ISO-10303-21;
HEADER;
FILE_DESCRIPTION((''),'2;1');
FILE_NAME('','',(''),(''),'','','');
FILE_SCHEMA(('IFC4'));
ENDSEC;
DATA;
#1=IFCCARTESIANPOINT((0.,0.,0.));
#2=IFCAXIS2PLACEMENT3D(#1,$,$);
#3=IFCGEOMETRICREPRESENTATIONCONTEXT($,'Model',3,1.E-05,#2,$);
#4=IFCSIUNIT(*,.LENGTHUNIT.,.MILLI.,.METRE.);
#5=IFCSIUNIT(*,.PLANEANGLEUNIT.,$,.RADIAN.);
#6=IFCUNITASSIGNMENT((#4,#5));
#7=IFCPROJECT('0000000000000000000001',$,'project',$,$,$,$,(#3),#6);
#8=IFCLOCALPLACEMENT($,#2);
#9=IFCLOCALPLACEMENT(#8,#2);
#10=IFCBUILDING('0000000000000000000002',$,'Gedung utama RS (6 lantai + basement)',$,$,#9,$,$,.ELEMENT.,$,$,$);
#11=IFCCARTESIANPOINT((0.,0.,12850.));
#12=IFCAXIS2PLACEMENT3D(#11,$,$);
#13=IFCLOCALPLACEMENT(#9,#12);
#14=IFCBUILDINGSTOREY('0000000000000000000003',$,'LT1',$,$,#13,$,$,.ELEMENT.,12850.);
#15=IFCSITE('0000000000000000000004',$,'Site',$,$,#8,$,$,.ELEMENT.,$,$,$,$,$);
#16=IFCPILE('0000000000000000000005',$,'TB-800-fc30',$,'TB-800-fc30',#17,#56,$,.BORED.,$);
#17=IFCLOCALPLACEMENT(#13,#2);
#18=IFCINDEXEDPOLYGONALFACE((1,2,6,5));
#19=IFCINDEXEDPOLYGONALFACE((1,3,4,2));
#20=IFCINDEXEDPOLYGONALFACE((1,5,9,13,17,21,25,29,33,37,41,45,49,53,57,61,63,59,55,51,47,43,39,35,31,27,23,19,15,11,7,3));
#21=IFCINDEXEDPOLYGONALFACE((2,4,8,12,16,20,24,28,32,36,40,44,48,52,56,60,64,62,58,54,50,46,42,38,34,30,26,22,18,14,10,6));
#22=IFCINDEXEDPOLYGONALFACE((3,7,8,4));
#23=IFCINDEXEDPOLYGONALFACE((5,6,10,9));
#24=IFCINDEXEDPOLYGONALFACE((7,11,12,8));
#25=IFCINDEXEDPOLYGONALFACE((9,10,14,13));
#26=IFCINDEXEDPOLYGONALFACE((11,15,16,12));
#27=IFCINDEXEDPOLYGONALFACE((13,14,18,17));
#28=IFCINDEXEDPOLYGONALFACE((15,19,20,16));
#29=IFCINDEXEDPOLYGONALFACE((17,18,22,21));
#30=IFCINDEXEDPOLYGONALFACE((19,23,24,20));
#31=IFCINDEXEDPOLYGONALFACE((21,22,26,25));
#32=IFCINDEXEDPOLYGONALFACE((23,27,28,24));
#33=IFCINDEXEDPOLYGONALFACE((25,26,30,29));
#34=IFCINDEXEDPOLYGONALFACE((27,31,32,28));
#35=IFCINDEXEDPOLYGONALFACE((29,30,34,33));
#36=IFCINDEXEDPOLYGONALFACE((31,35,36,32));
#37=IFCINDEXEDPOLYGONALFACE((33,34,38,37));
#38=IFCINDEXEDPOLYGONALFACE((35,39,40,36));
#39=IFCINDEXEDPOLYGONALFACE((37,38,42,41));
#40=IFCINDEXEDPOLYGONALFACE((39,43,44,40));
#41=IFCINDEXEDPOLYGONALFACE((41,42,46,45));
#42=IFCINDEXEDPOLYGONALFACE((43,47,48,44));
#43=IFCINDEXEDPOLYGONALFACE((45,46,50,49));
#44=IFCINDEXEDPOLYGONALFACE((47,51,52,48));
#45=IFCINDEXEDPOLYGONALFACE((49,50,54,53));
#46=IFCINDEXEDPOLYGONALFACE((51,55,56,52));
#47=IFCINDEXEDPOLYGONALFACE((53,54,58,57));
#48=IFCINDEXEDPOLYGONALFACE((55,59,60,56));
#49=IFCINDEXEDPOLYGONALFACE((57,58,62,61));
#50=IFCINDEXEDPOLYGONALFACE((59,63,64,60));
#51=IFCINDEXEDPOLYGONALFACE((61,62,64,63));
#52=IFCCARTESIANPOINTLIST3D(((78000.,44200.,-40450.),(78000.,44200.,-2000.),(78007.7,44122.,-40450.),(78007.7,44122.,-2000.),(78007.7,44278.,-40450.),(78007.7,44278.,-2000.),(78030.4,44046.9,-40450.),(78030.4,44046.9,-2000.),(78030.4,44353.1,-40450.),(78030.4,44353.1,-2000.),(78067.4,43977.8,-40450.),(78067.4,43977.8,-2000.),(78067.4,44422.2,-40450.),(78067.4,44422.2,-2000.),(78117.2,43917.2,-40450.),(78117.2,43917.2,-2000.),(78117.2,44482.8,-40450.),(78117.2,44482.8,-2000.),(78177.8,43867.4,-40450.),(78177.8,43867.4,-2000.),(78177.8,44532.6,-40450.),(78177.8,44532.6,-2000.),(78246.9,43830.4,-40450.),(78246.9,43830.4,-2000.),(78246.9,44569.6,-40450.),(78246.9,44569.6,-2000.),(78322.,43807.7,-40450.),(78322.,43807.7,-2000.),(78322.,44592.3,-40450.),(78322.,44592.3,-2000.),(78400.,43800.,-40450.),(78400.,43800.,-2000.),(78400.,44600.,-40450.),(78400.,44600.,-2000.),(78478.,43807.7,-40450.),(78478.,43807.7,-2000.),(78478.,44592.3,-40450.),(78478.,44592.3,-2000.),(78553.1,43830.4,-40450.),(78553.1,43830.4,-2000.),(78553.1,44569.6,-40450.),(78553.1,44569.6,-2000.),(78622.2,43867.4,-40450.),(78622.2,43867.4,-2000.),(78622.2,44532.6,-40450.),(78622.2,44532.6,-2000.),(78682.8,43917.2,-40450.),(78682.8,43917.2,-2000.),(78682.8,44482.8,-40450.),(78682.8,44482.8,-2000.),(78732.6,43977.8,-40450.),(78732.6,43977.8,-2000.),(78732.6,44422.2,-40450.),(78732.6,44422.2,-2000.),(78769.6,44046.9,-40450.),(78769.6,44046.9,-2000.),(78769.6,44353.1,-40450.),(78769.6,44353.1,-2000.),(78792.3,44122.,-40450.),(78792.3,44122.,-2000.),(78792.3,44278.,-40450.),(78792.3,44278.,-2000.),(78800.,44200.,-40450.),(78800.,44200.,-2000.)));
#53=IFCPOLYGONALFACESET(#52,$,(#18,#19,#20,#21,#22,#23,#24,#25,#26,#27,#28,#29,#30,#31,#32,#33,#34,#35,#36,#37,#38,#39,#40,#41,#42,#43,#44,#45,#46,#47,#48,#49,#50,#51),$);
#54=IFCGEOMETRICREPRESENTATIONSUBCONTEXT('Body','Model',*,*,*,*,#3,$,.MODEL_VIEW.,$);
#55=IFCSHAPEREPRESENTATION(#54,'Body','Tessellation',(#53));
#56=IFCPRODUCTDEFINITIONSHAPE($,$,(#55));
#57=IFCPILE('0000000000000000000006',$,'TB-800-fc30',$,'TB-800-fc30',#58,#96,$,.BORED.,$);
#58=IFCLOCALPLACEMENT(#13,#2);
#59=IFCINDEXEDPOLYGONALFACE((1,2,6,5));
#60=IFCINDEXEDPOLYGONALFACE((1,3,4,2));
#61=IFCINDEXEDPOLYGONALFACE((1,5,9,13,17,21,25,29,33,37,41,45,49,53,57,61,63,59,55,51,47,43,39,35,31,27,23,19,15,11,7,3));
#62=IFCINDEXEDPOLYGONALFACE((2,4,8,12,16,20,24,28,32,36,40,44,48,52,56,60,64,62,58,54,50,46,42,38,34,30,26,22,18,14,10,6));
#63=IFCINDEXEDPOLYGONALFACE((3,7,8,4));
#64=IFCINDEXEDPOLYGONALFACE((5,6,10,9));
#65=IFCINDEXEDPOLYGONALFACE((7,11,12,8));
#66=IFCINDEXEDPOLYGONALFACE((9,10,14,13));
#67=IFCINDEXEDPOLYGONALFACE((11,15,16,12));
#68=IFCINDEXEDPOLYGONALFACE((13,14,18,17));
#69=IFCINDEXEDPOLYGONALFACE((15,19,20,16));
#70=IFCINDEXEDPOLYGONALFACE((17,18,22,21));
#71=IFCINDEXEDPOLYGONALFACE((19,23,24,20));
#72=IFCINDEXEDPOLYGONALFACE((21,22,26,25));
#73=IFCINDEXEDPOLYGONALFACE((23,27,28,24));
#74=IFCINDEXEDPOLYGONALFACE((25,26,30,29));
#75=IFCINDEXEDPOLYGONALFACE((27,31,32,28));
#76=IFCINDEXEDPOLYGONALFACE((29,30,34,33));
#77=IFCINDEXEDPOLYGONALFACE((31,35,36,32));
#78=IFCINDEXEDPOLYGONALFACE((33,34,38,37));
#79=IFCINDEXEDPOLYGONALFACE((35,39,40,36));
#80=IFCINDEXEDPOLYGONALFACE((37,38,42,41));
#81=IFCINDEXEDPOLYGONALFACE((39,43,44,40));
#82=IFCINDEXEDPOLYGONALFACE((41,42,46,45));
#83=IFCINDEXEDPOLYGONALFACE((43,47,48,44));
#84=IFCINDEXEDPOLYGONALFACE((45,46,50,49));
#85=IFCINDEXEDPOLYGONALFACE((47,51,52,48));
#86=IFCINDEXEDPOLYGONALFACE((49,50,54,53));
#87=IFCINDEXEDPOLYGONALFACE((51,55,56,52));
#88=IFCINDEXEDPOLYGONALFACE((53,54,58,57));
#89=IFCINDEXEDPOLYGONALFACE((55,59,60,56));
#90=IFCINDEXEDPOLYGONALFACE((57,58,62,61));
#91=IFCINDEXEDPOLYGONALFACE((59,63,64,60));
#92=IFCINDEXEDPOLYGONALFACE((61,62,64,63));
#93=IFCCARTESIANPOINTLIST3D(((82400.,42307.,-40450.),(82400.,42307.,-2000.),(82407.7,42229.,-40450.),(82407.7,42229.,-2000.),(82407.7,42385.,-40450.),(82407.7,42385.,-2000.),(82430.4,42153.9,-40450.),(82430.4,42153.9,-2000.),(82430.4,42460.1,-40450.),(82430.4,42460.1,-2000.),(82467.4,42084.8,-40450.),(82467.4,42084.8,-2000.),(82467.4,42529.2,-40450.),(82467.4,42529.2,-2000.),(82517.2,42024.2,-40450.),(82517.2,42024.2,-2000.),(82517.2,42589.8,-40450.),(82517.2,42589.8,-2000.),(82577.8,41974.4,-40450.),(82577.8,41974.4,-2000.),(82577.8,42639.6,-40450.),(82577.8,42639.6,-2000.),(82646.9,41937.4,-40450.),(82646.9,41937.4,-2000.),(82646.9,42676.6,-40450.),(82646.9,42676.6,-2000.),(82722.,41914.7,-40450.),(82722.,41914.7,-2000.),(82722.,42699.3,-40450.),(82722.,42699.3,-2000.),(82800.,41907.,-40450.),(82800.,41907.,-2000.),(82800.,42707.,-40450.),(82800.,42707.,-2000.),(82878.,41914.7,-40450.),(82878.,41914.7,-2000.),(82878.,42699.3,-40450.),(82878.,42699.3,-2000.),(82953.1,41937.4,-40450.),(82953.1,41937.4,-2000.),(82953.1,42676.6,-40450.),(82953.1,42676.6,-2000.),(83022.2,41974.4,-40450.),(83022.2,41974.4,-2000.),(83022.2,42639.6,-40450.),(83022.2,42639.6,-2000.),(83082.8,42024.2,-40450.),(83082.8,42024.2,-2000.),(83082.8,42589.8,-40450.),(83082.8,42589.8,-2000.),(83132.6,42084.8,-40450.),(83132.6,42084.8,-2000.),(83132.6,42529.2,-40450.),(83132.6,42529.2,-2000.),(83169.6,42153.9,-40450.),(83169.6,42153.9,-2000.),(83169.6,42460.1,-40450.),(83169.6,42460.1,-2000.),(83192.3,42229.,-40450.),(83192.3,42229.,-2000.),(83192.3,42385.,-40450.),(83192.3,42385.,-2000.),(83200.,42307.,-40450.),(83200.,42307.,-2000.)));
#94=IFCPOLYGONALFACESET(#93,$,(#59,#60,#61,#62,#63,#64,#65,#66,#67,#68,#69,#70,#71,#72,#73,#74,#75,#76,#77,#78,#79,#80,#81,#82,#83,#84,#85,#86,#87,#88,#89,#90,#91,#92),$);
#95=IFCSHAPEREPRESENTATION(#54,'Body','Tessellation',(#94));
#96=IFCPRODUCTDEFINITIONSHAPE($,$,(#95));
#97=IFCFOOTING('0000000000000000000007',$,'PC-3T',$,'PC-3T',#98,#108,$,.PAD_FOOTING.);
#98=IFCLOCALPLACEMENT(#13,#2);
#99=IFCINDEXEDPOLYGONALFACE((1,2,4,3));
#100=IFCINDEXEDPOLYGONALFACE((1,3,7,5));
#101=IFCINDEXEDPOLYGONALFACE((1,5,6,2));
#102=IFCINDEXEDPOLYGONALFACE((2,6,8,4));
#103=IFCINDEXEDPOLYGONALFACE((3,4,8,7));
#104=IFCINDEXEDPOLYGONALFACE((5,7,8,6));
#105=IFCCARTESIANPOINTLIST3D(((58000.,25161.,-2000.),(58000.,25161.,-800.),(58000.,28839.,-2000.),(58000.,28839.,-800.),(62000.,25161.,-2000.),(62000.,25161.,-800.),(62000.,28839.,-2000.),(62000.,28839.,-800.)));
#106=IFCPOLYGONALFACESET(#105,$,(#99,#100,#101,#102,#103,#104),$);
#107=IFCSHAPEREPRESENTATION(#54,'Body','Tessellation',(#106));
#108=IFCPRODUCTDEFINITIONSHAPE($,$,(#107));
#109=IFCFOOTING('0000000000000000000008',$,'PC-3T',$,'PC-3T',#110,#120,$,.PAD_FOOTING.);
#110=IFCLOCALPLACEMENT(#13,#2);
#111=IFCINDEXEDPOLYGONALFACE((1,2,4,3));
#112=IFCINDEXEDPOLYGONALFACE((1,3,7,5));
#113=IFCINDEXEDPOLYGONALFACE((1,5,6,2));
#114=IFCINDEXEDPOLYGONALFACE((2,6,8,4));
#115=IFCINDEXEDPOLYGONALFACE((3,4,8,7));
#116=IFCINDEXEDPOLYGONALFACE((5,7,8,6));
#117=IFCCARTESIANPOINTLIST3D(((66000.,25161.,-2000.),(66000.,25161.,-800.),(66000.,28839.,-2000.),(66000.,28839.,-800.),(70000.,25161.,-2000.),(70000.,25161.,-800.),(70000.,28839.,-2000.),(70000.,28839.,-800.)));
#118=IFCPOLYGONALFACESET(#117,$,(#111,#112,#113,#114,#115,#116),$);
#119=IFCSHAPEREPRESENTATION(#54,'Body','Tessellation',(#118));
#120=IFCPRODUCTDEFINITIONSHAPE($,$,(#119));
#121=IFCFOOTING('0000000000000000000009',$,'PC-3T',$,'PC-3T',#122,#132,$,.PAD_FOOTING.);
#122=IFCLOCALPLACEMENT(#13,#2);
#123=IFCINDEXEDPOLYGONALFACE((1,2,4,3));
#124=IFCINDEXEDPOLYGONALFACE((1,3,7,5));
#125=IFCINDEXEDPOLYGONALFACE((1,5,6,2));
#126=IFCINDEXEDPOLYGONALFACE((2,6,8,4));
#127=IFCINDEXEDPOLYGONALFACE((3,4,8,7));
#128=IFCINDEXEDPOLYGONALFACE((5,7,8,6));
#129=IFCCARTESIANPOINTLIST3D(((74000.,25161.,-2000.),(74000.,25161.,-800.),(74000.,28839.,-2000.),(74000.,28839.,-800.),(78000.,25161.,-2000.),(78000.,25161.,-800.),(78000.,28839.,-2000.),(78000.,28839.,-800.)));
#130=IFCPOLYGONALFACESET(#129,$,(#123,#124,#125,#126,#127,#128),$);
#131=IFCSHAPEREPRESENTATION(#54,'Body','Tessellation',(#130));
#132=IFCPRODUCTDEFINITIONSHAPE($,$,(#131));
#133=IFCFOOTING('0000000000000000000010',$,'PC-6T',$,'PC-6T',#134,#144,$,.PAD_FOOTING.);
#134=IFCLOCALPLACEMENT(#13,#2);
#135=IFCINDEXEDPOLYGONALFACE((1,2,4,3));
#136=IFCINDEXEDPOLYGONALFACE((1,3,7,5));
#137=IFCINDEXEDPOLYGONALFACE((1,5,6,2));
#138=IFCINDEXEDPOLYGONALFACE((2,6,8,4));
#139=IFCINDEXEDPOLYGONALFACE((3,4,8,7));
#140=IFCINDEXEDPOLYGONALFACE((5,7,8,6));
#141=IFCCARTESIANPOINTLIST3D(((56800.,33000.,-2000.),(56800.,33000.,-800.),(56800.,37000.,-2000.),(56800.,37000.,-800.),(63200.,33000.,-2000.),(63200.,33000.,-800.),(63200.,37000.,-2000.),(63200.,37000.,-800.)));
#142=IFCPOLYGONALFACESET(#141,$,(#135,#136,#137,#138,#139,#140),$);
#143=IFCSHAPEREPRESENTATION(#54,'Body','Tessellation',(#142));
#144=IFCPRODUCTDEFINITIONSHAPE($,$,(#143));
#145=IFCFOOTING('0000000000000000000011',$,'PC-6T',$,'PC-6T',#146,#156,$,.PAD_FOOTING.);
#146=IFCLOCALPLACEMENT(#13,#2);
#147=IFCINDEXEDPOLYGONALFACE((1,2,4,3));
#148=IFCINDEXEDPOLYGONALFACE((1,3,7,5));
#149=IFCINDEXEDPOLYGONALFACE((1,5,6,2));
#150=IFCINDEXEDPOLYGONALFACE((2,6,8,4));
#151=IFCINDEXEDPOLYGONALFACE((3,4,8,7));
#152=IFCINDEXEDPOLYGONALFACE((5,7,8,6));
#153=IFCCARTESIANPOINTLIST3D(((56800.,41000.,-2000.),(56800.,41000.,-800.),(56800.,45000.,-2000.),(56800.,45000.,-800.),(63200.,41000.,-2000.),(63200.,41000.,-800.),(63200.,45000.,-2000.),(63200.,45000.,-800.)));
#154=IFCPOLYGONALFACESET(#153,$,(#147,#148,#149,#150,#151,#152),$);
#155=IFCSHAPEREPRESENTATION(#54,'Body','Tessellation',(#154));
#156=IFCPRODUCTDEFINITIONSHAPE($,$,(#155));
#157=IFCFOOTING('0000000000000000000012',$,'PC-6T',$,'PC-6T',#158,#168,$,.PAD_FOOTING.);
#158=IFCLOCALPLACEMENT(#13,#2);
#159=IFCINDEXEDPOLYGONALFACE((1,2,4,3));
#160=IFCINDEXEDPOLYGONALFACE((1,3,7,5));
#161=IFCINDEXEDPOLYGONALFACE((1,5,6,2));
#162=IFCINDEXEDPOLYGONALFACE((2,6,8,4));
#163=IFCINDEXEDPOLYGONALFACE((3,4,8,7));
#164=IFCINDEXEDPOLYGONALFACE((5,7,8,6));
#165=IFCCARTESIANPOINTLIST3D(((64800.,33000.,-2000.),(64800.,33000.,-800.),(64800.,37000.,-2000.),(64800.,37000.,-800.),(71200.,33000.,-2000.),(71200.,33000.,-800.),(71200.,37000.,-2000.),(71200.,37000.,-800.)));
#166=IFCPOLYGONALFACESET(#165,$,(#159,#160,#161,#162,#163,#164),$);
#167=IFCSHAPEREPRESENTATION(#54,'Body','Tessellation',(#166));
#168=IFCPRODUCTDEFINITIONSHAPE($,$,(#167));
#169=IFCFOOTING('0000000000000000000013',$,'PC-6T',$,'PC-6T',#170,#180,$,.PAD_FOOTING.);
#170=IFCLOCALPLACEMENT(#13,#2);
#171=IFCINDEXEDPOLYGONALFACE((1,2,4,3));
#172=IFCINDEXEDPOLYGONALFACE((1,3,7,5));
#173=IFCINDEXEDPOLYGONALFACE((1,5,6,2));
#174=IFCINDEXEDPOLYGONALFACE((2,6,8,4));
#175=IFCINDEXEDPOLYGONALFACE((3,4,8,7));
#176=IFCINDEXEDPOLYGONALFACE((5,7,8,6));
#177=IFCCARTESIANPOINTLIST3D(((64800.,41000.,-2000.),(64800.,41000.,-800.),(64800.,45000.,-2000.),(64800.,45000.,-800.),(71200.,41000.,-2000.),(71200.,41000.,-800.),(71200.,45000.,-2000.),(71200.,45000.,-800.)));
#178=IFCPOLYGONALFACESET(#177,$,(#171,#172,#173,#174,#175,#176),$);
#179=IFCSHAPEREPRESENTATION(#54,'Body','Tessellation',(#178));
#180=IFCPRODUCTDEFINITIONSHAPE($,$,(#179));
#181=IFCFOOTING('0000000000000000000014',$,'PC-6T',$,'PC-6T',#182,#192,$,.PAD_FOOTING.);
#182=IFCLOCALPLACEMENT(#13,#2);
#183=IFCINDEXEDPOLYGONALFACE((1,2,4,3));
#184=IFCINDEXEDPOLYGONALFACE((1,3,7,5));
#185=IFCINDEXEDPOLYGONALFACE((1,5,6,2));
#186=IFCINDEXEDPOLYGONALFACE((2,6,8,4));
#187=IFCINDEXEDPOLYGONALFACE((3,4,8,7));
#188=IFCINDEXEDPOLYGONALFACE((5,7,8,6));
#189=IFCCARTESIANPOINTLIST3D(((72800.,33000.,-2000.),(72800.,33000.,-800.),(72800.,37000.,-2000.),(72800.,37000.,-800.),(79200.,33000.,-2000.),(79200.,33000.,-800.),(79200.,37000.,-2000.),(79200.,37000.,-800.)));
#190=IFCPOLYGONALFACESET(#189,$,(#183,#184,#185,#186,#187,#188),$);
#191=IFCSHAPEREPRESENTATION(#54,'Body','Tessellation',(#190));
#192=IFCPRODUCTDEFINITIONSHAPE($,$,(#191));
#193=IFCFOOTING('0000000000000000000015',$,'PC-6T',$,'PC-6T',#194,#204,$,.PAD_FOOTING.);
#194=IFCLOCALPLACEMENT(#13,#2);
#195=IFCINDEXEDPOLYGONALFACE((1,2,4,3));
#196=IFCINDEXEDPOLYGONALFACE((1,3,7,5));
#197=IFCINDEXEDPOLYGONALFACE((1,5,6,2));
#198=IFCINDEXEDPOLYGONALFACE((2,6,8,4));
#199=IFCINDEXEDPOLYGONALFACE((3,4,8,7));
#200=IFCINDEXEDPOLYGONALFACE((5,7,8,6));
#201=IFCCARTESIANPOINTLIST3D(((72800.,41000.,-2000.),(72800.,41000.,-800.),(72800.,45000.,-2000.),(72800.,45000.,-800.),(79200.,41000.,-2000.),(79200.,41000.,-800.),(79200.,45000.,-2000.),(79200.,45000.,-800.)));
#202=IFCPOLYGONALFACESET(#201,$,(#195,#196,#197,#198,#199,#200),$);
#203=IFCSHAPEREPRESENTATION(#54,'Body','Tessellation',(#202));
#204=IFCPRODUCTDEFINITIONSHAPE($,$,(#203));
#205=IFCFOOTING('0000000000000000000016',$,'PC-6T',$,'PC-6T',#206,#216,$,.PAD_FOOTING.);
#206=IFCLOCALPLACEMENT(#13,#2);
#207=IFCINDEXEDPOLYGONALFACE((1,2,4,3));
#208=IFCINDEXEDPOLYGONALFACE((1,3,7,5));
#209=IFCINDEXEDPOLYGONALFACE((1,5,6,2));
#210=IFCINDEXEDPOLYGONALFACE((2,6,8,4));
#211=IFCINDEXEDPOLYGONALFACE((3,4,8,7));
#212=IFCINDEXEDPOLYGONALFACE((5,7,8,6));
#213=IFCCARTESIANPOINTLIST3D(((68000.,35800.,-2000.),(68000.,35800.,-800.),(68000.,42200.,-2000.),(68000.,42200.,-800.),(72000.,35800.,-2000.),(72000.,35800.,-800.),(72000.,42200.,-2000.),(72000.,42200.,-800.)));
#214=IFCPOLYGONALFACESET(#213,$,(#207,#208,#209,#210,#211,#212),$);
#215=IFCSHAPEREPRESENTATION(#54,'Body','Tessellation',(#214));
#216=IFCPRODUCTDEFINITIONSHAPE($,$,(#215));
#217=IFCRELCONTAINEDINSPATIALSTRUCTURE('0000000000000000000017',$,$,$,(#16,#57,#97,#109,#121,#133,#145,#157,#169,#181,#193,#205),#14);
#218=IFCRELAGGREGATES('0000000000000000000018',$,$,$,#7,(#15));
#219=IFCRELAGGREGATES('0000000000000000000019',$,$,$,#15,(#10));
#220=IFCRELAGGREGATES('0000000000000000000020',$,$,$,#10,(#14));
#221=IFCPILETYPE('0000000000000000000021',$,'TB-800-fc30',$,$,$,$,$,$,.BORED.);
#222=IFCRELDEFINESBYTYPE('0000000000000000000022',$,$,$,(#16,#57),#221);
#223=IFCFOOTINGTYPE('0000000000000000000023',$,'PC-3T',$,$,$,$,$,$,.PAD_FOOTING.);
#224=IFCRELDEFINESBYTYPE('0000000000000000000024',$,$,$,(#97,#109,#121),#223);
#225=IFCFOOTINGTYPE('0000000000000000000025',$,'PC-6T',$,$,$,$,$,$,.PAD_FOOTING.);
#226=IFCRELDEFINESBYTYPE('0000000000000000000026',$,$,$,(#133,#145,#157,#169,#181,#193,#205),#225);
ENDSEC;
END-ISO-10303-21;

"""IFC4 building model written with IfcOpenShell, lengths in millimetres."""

from ifc_helpers import new_model, si_unit, frame, origin, origin_2d, place, context, subcontext, project, spatial, rectangle, circle, extrude, material_profile, profile_set, profile_usage, type_object, element, save


model = new_model("IFC4")

# Units and contexts
model_context = context("Model", 3, precision=1e-05, world=origin())
body_context = subcontext(model_context, "Body", "Model", "MODEL_VIEW")
ifc_project = project(units=[si_unit("LENGTHUNIT", "METRE", prefix="MILLI"), si_unit("PLANEANGLEUNIT", "RADIAN")], contexts=[model_context])

# Site, building, storey
site_placement = place(None, origin())
site = spatial("IfcSite", under=ifc_project, at=site_placement, Name="Site", CompositionType="ELEMENT")
building_placement = place(site_placement, origin())
building = spatial("IfcBuilding", under=site, at=building_placement, Name="Gedung utama RS (6 lantai + basement)", CompositionType="ELEMENT")
storey_placement = place(building_placement, frame((0.0, 0.0, 12850.0)))
storey = spatial("IfcBuildingStorey", under=building, at=storey_placement, Name="LT1", CompositionType="ELEMENT", Elevation=12850.0)

# Piles
ifc_material_profile_1 = material_profile(None, circle(Radius=400.0, at=origin_2d()), Name="TB-800-fc30")
ifc_profile_set_1 = profile_set([ifc_material_profile_1], Name="TB-800-fc30")
ifc_profile_usage_1 = profile_usage(ifc_profile_set_1, cardinal=5)
pile_type = type_object("IfcPileType", Name="TB-800-fc30", PredefinedType="BORED", material=ifc_profile_set_1)
for number, where, z_axis, x_axis, name in (
    (1, (78400.0, 44200.0, -40450.0), (0.0, 0.0, 1.0), (1.0, 0.0, 0.0), "TB-800-fc30"),
    (2, (82800.0, 42307.0, -40450.0), (0.0, 0.0, 1.0), (1.0, 0.0, 0.0), "TB-800-fc30"),
):
    element("IfcPile", number, at=place(storey_placement, frame(where, z_axis=z_axis, x_axis=x_axis)), inside=storey, type_object=pile_type, material=ifc_profile_usage_1, Name=name, ObjectType="TB-800-fc30", PredefinedType="BORED", context=body_context, shape_type="SweptSolid", body=[
        extrude(circle(Radius=400.0, at=origin_2d()), origin(), (0.0, 0.0, 1.0), 38450.0),
    ])

# Footings
ifc_material_profile_2 = material_profile(None, rectangle(XDim=4000.0, YDim=3678.0, at=origin_2d()), Name="PC-3T")
ifc_profile_set_2 = profile_set([ifc_material_profile_2], Name="PC-3T")
ifc_profile_usage_2 = profile_usage(ifc_profile_set_2, cardinal=5)
footing_type_1 = type_object("IfcFootingType", Name="PC-3T", PredefinedType="PAD_FOOTING", material=ifc_profile_set_2)
for number, where, z_axis, x_axis, name in (
    (3, (60000.0, 27000.0, -2000.0), (0.0, 0.0, 1.0), (1.0, 0.0, 0.0), "PC-3T"),
    (4, (68000.0, 27000.0, -2000.0), (0.0, 0.0, 1.0), (1.0, 0.0, 0.0), "PC-3T"),
    (5, (76000.0, 27000.0, -2000.0), (0.0, 0.0, 1.0), (1.0, 0.0, 0.0), "PC-3T"),
):
    element("IfcFooting", number, at=place(storey_placement, frame(where, z_axis=z_axis, x_axis=x_axis)), inside=storey, type_object=footing_type_1, material=ifc_profile_usage_2, Name=name, ObjectType="PC-3T", PredefinedType="PAD_FOOTING", context=body_context, shape_type="SweptSolid", body=[
        extrude(rectangle(XDim=4000.0, YDim=3678.0, at=origin_2d()), origin(), (0.0, 0.0, 1.0), 1200.0),
    ])
ifc_material_profile_3 = material_profile(None, rectangle(XDim=6400.0, YDim=4000.0, at=origin_2d()), Name="PC-6T")
ifc_profile_set_3 = profile_set([ifc_material_profile_3], Name="PC-6T")
ifc_profile_usage_3 = profile_usage(ifc_profile_set_3, cardinal=5)
footing_type_2 = type_object("IfcFootingType", Name="PC-6T", PredefinedType="PAD_FOOTING", material=ifc_profile_set_3)
for number, where, z_axis, x_axis, name in (
    (6, (60000.0, 35000.0, -2000.0), (0.0, 0.0, 1.0), (1.0, 0.0, 0.0), "PC-6T"),
    (7, (60000.0, 43000.0, -2000.0), (0.0, 0.0, 1.0), (1.0, 0.0, 0.0), "PC-6T"),
    (8, (68000.0, 35000.0, -2000.0), (0.0, 0.0, 1.0), (1.0, 0.0, 0.0), "PC-6T"),
    (9, (68000.0, 43000.0, -2000.0), (0.0, 0.0, 1.0), (1.0, 0.0, 0.0), "PC-6T"),
    (10, (76000.0, 35000.0, -2000.0), (0.0, 0.0, 1.0), (1.0, 0.0, 0.0), "PC-6T"),
    (11, (76000.0, 43000.0, -2000.0), (0.0, 0.0, 1.0), (1.0, 0.0, 0.0), "PC-6T"),
    (12, (70000.0, 39000.0, -2000.0), (0.0, 0.0, 1.0), (0.0, 1.0, 0.0), "PC-6T"),
):
    element("IfcFooting", number, at=place(storey_placement, frame(where, z_axis=z_axis, x_axis=x_axis)), inside=storey, type_object=footing_type_2, material=ifc_profile_usage_3, Name=name, ObjectType="PC-6T", PredefinedType="PAD_FOOTING", context=body_context, shape_type="SweptSolid", body=[
        extrude(rectangle(XDim=6400.0, YDim=4000.0, at=origin_2d()), origin(), (0.0, 0.0, 1.0), 1200.0),
    ])

save(model, "model.ifc")
